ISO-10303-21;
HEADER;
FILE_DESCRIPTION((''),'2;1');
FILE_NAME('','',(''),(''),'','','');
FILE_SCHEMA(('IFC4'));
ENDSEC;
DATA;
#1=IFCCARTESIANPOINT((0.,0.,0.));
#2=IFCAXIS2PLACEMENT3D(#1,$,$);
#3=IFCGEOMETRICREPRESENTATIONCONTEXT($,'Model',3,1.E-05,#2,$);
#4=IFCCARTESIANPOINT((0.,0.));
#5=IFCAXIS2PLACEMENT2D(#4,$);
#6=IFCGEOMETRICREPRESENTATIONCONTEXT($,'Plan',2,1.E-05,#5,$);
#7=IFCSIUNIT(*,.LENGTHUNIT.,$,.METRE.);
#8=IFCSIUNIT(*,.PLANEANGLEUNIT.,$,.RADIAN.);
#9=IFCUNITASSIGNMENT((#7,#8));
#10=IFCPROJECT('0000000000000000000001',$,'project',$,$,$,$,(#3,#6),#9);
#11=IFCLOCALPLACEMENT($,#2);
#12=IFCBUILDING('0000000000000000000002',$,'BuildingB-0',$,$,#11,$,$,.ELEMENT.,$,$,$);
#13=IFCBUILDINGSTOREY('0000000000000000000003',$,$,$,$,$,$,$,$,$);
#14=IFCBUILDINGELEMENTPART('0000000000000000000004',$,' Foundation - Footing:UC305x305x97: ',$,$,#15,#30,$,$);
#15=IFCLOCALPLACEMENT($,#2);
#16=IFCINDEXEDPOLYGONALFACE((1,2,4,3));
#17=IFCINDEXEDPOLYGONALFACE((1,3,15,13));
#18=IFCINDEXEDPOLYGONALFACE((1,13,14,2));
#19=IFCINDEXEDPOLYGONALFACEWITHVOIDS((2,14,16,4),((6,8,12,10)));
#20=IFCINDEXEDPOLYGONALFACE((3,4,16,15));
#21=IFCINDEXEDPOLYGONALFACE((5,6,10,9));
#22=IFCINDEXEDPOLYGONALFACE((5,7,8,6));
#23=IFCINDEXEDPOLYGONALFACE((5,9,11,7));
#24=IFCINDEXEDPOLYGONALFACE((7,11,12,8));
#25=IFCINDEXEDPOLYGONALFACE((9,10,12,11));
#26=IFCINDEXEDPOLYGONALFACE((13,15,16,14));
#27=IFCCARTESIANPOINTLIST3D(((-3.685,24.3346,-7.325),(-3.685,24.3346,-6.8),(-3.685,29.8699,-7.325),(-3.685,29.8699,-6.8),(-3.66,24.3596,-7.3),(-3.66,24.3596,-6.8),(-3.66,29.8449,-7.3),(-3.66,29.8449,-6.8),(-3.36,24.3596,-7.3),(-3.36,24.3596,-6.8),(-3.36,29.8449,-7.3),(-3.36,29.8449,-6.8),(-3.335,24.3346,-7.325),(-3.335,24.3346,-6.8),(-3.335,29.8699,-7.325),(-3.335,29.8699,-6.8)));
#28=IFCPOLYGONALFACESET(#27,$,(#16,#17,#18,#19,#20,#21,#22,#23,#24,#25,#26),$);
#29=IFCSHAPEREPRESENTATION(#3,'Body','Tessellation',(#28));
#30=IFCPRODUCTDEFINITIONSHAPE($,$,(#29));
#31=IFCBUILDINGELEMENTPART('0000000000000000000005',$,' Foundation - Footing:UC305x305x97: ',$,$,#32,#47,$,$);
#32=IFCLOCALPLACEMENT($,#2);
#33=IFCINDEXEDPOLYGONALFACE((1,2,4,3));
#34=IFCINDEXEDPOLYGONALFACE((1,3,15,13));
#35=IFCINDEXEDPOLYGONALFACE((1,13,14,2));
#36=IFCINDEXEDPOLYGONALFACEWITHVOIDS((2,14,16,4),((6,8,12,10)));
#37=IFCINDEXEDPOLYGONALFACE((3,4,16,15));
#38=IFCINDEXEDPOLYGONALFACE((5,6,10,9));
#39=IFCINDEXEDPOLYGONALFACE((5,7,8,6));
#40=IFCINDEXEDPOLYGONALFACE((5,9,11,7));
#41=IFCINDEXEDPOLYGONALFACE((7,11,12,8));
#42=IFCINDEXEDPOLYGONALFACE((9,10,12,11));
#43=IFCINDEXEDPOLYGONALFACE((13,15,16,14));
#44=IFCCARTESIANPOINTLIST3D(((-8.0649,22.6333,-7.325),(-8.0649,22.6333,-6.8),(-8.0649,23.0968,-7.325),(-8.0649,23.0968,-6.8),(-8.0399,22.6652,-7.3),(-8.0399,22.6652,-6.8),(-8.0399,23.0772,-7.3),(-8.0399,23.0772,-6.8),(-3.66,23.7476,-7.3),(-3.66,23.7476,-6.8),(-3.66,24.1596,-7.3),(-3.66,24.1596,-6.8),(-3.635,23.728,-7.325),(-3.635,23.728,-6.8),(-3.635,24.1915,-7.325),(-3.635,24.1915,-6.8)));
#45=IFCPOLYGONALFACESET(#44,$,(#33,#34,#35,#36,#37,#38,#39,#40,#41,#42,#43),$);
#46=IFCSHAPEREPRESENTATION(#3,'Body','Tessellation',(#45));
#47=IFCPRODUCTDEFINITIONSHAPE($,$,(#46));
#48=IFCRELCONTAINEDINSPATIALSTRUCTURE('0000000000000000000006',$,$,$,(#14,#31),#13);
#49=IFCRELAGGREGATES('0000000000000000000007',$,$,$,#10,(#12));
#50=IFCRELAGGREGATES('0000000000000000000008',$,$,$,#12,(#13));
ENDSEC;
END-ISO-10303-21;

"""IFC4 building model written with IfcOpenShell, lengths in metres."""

from ifc_helpers import new_model, si_unit, origin, origin_2d, place, context, project, spatial, polyline, outline, extrude, element, save


model = new_model("IFC4")

# Units and contexts
model_context = context("Model", 3, precision=1e-05, world=origin())
plan_context = context("Plan", 2, precision=1e-05, world=origin_2d())
ifc_project = project(units=[si_unit("LENGTHUNIT", "METRE"), si_unit("PLANEANGLEUNIT", "RADIAN")], contexts=[model_context, plan_context])

# Building, storey
building_placement = place(None, origin())
building = spatial("IfcBuilding", under=ifc_project, at=building_placement, Name="BuildingB-0", CompositionType="ELEMENT")
storey = spatial("IfcBuildingStorey", under=building)

# Building element parts, openings
building_element_part_1 = element("IfcBuildingElementPart", 1, inside=storey, Name=" Foundation - Footing:UC305x305x97: ", context=model_context, shape_type="SweptSolid", body=[
    extrude(outline(polyline([(-3.685, 29.8699, -7.325), (-3.335, 29.8699, -7.325), (-3.335, 24.3346, -7.325), (-3.685, 24.3346, -7.325), (-3.685, 29.8699, -7.325)])), None, (0.0, 0.0, 1.0), 0.525),
])
element("IfcOpeningElement", 2, inside=storey, cuts=building_element_part_1, context=model_context, shape_type="SweptSolid", body=[
    extrude(outline(polyline([(-3.66, 29.8449, -7.3), (-3.36, 29.8449, -7.3), (-3.36, 24.3596, -7.3), (-3.66, 24.3596, -7.3), (-3.66, 29.8449, -7.3)])), None, (0.0, 0.0, 1.0), 0.5),
])
building_element_part_2 = element("IfcBuildingElementPart", 3, inside=storey, Name=" Foundation - Footing:UC305x305x97: ", context=model_context, shape_type="SweptSolid", body=[
    extrude(outline(polyline([(-3.635, 24.1915, -7.325), (-3.635, 23.728, -7.325), (-8.0649, 22.6333, -7.325), (-8.0649, 23.0968, -7.325), (-3.635, 24.1915, -7.325)])), None, (0.0, 0.0, 1.0), 0.525),
])
element("IfcOpeningElement", 4, inside=storey, cuts=building_element_part_2, context=model_context, shape_type="SweptSolid", body=[
    extrude(outline(polyline([(-3.66, 24.1596, -7.3), (-3.66, 23.7476, -7.3), (-8.0399, 22.6652, -7.3), (-8.0399, 23.0772, -7.3), (-3.66, 24.1596, -7.3)])), None, (0.0, 0.0, 1.0), 0.5),
])

save(model, "model.ifc")
